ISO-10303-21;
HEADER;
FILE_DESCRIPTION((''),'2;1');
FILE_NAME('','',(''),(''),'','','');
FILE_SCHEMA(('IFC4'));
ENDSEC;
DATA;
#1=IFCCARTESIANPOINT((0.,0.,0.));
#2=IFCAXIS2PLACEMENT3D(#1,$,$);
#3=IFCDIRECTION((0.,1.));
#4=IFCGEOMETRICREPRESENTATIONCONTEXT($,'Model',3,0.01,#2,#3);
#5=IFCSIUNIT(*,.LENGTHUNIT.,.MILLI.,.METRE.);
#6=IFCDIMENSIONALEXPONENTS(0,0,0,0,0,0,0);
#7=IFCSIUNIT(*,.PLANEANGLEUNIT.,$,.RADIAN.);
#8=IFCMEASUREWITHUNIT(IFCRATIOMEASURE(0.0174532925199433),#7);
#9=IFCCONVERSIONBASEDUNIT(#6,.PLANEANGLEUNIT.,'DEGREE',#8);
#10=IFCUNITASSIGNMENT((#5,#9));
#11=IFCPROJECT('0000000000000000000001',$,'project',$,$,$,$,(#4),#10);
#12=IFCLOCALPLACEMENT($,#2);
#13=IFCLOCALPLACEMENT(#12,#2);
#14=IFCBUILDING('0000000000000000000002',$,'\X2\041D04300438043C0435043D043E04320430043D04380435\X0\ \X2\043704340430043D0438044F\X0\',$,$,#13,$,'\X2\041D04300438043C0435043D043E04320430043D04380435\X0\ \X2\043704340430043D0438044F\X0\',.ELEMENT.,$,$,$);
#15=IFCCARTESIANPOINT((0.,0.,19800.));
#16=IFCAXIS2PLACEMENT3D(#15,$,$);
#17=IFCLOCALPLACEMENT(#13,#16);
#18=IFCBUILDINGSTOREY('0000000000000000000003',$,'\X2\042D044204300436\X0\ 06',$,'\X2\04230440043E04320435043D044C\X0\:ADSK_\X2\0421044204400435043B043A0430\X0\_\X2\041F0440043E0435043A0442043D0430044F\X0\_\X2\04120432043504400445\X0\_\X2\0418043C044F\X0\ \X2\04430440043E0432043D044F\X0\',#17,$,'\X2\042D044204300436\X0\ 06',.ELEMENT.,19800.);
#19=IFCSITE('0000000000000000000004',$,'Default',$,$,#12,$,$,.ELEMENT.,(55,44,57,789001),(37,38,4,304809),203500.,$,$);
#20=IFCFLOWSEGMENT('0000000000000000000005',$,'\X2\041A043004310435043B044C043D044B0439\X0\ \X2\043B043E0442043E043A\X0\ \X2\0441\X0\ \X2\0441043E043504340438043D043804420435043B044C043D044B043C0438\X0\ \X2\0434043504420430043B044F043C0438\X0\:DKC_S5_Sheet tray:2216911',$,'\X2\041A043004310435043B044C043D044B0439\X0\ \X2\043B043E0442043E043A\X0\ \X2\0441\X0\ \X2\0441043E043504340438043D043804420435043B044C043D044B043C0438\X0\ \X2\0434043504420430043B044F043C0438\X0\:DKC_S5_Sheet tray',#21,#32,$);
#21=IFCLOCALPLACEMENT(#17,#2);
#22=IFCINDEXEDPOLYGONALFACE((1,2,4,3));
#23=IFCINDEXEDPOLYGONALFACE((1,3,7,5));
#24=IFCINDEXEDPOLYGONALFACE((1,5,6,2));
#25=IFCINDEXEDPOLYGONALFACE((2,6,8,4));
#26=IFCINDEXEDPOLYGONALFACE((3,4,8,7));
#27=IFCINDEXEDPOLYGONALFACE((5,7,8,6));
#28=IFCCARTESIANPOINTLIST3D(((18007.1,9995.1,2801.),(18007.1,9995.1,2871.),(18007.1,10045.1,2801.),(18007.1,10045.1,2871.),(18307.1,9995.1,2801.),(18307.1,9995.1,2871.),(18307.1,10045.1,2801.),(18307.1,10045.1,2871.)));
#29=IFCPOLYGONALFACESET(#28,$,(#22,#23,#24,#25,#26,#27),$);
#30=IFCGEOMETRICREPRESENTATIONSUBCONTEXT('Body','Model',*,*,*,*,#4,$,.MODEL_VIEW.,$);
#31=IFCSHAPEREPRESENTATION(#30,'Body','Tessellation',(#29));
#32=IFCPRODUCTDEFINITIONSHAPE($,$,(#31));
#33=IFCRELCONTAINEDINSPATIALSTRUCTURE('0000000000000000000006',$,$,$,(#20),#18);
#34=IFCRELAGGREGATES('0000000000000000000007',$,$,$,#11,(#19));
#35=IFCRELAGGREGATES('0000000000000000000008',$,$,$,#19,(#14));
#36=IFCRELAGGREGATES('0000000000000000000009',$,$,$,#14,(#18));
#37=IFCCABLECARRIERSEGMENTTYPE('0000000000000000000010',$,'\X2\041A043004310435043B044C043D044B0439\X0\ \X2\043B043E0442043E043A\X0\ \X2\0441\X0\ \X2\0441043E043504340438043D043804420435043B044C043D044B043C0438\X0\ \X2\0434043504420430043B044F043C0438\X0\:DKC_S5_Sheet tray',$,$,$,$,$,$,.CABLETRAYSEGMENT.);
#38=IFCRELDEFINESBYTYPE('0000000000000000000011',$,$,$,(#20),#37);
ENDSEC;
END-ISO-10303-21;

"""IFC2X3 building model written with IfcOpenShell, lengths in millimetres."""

from ifc_helpers import new_model, entity, si_unit, converted_unit, direction, frame, origin, origin_2d_with_axis, place, context, subcontext, project, spatial, rectangle, extrude, type_object, element, save


model = new_model("IFC2X3")

# Units and contexts
model_context = context("Model", 3, precision=0.01, world=origin(), true_north=direction((0.0, 1.0)))
body_context = subcontext(model_context, "Body", "Model", "MODEL_VIEW")
ifc_project = project(units=[si_unit("LENGTHUNIT", "METRE", prefix="MILLI"), converted_unit("PLANEANGLEUNIT", "DEGREE", entity("IfcRatioMeasure", 0.0174532925199433), si_unit("PLANEANGLEUNIT", "RADIAN"), dimensions=[0, 0, 0, 0, 0, 0, 0])], contexts=[model_context])

# Site, building, storey
site_placement = place(None, origin())
site = spatial("IfcSite", under=ifc_project, at=site_placement, Name="Default", CompositionType="ELEMENT", RefLatitude=(55, 44, 57, 789001), RefLongitude=(37, 38, 4, 304809), RefElevation=203500.0)
building_placement = place(site_placement, origin())
building = spatial("IfcBuilding", under=site, at=building_placement, Name="Наименование здания", LongName="Наименование здания", CompositionType="ELEMENT")
storey_placement = place(building_placement, frame((0.0, 0.0, 19800.0)))
storey = spatial("IfcBuildingStorey", under=building, at=storey_placement, Name="Этаж 06", ObjectType="Уровень:ADSK_Стрелка_Проектная_Вверх_Имя уровня", LongName="Этаж 06", CompositionType="ELEMENT", Elevation=19800.0)

# Flow segment
cable_carrier_segment_type = type_object("IfcCableCarrierSegmentType", Name="Кабельный лоток с соединительными деталями:DKC_S5_Sheet tray", PredefinedType="CABLETRAYSEGMENT")
flow_segment_1_placement = place(storey_placement, frame((18007.1, 9995.1, 2801.0)))
element("IfcFlowSegment", 1, at=flow_segment_1_placement, inside=storey, type_object=cable_carrier_segment_type, Name="Кабельный лоток с соединительными деталями:DKC_S5_Sheet tray:2216911", ObjectType="Кабельный лоток с соединительными деталями:DKC_S5_Sheet tray", context=body_context, shape_type="SweptSolid", body=[
    extrude(rectangle(XDim=50.0, YDim=300.0, at=origin_2d_with_axis()), frame((150.0, 25.0, 0.0), z_axis=(0.0, 0.0, 1.0), x_axis=(0.0, -1.0, 0.0)), (0.0, 0.0, 1.0), 70.0),
])

save(model, "model.ifc")
